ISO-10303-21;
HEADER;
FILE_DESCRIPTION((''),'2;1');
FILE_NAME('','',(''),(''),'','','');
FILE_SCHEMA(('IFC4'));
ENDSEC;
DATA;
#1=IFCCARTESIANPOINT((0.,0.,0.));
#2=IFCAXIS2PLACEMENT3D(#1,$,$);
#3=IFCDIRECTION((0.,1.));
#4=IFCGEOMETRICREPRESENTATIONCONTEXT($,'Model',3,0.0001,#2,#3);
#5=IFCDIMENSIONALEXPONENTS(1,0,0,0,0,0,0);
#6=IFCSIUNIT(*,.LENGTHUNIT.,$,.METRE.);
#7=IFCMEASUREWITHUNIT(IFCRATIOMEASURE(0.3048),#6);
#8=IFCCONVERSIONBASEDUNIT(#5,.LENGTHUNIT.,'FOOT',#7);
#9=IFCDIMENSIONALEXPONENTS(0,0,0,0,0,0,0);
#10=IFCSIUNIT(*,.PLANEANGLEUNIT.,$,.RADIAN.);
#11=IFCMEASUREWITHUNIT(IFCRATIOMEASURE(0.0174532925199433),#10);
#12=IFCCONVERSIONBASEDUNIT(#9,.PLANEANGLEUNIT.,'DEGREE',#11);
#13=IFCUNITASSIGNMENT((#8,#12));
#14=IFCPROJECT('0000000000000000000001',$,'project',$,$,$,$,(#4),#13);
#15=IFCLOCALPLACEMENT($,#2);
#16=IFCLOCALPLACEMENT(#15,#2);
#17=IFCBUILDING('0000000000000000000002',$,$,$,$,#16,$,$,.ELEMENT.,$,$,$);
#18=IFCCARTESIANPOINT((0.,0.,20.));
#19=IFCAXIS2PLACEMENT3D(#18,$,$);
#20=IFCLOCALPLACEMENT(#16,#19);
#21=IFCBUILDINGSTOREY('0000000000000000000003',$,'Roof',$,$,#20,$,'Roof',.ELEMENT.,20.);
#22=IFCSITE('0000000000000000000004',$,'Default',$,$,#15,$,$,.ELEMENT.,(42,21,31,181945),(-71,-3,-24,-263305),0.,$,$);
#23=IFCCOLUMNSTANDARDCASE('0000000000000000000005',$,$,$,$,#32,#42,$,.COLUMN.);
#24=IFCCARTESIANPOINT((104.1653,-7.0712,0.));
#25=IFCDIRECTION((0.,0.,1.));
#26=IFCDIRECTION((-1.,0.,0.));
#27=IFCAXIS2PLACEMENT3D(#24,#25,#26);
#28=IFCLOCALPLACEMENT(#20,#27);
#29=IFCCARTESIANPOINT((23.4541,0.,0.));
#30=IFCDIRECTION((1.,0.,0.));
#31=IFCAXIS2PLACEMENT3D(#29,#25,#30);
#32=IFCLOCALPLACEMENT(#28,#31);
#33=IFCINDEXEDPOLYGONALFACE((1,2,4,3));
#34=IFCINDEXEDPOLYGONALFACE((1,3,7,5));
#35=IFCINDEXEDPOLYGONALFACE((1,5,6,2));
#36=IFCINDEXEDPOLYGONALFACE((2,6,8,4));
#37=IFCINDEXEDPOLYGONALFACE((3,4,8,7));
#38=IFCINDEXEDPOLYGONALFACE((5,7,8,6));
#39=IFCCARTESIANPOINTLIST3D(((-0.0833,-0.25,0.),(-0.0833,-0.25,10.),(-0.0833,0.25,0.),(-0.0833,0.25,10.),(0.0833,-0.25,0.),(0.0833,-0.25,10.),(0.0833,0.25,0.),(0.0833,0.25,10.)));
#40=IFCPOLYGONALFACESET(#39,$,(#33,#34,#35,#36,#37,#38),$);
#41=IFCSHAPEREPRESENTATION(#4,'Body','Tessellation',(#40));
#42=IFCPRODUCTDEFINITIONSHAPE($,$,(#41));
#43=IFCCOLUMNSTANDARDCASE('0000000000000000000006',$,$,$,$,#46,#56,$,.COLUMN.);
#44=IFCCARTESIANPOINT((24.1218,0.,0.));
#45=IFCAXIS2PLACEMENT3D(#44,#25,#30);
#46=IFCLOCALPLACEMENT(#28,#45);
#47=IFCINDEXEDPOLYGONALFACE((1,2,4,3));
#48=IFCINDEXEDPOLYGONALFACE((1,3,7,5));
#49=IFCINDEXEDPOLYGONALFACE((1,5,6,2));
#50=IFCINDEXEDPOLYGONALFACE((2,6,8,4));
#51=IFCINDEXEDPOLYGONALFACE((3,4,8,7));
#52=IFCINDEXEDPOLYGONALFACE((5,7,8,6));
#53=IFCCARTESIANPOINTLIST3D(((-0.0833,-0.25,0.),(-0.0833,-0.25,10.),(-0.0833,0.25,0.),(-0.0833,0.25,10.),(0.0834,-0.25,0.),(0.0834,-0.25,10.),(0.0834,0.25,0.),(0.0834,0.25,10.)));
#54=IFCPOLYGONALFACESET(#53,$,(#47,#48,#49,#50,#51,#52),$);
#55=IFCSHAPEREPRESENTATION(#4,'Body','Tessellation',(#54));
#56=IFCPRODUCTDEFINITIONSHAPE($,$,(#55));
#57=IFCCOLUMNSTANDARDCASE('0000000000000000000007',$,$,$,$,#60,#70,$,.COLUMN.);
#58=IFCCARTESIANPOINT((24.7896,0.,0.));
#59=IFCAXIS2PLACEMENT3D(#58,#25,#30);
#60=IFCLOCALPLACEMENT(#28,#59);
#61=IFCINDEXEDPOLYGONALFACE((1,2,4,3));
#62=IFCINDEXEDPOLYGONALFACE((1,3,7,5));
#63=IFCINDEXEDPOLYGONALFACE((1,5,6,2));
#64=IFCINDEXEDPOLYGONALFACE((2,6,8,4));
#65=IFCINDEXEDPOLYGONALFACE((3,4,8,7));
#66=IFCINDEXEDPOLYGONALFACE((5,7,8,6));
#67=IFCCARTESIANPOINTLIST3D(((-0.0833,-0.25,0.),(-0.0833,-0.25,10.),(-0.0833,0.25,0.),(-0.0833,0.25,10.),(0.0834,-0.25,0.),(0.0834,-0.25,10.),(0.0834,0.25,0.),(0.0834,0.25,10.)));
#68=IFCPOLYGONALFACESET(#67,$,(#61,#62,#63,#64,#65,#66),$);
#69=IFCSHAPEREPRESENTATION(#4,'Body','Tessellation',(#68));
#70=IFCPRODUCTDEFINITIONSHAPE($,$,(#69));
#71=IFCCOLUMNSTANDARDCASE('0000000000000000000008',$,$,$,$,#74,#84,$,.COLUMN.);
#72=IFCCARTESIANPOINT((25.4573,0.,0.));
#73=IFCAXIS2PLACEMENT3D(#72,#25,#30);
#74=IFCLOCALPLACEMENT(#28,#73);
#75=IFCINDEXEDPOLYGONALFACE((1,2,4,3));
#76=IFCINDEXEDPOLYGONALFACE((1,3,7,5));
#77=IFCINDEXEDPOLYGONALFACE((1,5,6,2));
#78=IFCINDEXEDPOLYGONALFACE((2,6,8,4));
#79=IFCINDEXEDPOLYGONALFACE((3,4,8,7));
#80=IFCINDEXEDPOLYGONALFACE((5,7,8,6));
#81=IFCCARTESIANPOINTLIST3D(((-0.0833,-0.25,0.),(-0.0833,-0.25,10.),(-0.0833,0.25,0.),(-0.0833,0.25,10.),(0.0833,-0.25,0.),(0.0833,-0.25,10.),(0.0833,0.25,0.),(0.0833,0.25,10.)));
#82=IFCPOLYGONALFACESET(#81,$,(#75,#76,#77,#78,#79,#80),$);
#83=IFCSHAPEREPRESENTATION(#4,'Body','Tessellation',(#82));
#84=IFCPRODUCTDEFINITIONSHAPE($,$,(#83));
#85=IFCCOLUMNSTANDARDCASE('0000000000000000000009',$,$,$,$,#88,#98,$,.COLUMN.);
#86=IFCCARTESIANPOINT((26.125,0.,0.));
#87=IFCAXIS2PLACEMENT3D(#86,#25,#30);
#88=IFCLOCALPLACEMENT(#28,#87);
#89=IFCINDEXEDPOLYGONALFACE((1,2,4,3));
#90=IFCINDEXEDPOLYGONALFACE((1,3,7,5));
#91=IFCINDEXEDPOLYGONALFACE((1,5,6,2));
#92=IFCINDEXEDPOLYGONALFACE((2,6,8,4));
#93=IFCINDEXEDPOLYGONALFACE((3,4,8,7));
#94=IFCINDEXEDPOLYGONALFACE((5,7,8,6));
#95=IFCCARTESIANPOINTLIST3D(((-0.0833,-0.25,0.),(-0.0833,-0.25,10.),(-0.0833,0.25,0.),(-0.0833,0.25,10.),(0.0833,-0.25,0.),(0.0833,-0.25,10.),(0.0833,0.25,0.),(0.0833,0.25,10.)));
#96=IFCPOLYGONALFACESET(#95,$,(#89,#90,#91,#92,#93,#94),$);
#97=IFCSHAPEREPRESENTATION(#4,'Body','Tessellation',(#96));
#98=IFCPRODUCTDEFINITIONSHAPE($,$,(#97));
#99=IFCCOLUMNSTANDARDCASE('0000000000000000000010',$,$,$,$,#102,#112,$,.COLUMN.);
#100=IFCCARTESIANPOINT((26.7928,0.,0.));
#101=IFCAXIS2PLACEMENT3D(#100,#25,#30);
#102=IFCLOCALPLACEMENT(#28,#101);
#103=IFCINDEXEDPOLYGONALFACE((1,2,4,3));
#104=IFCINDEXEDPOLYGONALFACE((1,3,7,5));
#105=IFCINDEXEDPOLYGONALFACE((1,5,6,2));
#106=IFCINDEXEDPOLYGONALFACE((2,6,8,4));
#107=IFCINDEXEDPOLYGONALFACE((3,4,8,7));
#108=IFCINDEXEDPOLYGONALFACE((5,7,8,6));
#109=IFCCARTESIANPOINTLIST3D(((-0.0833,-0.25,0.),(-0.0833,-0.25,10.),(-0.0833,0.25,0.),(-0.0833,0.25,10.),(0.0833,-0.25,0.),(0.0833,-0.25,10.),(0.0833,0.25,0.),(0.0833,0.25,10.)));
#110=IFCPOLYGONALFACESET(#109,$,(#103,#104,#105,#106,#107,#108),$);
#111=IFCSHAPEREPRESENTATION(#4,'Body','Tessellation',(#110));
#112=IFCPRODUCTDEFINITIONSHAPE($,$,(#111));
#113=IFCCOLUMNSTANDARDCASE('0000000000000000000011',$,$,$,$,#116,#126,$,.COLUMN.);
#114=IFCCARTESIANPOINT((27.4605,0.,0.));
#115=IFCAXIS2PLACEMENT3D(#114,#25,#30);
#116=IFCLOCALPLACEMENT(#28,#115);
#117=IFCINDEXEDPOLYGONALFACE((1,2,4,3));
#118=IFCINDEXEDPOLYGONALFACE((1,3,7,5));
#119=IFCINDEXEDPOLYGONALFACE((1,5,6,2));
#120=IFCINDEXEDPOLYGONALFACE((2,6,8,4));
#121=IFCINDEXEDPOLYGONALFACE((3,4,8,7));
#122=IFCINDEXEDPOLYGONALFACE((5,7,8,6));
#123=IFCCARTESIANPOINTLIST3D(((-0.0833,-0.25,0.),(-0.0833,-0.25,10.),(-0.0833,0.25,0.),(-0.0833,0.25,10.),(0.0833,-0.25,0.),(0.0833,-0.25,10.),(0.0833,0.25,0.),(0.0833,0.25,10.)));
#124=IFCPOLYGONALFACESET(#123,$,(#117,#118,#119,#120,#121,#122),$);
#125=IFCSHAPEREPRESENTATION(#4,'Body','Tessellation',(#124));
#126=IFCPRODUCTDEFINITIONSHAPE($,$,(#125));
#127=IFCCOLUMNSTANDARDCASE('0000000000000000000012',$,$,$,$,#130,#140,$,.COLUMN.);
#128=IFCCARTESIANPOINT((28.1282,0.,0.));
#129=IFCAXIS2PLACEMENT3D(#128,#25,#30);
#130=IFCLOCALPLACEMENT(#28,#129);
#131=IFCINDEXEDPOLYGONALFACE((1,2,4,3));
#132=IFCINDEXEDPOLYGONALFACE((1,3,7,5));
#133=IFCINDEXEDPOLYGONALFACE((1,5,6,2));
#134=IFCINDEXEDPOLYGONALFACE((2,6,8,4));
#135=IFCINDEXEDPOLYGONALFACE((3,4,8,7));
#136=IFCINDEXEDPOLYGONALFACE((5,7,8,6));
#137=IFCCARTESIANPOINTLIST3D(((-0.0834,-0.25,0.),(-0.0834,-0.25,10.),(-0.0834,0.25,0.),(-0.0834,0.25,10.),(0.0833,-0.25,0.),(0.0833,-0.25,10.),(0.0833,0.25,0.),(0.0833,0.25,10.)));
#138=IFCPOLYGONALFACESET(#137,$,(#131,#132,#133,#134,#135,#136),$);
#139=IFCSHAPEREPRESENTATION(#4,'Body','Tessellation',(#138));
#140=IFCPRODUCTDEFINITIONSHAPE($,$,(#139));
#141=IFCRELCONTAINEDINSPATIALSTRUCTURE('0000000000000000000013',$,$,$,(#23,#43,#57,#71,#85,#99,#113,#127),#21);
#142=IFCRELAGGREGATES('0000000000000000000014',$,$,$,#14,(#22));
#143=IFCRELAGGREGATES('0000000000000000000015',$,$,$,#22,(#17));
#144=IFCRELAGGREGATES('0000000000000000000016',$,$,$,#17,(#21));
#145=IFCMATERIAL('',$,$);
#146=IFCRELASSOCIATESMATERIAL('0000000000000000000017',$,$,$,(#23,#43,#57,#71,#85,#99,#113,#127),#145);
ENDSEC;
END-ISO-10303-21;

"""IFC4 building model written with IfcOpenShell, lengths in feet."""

from ifc_helpers import new_model, entity, si_unit, converted_unit, direction, frame, origin, place, context, project, spatial, rectangle, extrude, material, element, save


model = new_model("IFC4")

# Units and contexts
model_context = context("Model", 3, precision=0.0001, world=origin(), true_north=direction((0.0, 1.0)))
ifc_project = project(units=[converted_unit("LENGTHUNIT", "FOOT", entity("IfcRatioMeasure", 0.3048), si_unit("LENGTHUNIT", "METRE"), dimensions=[1, 0, 0, 0, 0, 0, 0]), converted_unit("PLANEANGLEUNIT", "DEGREE", entity("IfcRatioMeasure", 0.0174532925199433), si_unit("PLANEANGLEUNIT", "RADIAN"), dimensions=[0, 0, 0, 0, 0, 0, 0])], contexts=[model_context])

# Site, building, storey
site_placement = place(None, origin())
site = spatial("IfcSite", under=ifc_project, at=site_placement, Name="Default", CompositionType="ELEMENT", RefLatitude=(42, 21, 31, 181945), RefLongitude=(-71, -3, -24, -263305), RefElevation=0.0)
building_placement = place(site_placement, origin())
building = spatial("IfcBuilding", under=site, at=building_placement, CompositionType="ELEMENT")
storey_placement = place(building_placement, frame((0.0, 0.0, 20.0)))
storey = spatial("IfcBuildingStorey", under=building, at=storey_placement, Name="Roof", LongName="Roof", CompositionType="ELEMENT", Elevation=20.0)

# Columns
ifc_material_1 = material(Name="")
placement_1 = place(storey_placement, frame((104.1653, -7.0712, 0.0), z_axis=(0.0, 0.0, 1.0), x_axis=(-1.0, 0.0, 0.0)))
for number, where, z_axis, x_axis in (
    (1, (23.4541, 0.0, 0.0), (0.0, 0.0, 1.0), (1.0, 0.0, 0.0)),
    (2, (24.1218, 0.0, 0.0), (0.0, 0.0, 1.0), (1.0, 0.0, 0.0)),
    (3, (24.7896, 0.0, 0.0), (0.0, 0.0, 1.0), (1.0, 0.0, 0.0)),
    (4, (25.4573, 0.0, 0.0), (0.0, 0.0, 1.0), (1.0, 0.0, 0.0)),
    (5, (26.125, 0.0, 0.0), (0.0, 0.0, 1.0), (1.0, 0.0, 0.0)),
    (6, (26.7928, 0.0, 0.0), (0.0, 0.0, 1.0), (1.0, 0.0, 0.0)),
    (7, (27.4605, 0.0, 0.0), (0.0, 0.0, 1.0), (1.0, 0.0, 0.0)),
    (8, (28.1282, 0.0, 0.0), (0.0, 0.0, 1.0), (1.0, 0.0, 0.0)),
):
    element("IfcColumnStandardCase", number, at=place(placement_1, frame(where, z_axis=z_axis, x_axis=x_axis)), inside=storey, material=ifc_material_1, PredefinedType="COLUMN", context=model_context, shape_type="SweptSolid", body=[
        extrude(rectangle(XDim=0.1667, YDim=0.5), origin(), (0.0, 0.0, 1.0), 10.0),
    ])

save(model, "model.ifc")
